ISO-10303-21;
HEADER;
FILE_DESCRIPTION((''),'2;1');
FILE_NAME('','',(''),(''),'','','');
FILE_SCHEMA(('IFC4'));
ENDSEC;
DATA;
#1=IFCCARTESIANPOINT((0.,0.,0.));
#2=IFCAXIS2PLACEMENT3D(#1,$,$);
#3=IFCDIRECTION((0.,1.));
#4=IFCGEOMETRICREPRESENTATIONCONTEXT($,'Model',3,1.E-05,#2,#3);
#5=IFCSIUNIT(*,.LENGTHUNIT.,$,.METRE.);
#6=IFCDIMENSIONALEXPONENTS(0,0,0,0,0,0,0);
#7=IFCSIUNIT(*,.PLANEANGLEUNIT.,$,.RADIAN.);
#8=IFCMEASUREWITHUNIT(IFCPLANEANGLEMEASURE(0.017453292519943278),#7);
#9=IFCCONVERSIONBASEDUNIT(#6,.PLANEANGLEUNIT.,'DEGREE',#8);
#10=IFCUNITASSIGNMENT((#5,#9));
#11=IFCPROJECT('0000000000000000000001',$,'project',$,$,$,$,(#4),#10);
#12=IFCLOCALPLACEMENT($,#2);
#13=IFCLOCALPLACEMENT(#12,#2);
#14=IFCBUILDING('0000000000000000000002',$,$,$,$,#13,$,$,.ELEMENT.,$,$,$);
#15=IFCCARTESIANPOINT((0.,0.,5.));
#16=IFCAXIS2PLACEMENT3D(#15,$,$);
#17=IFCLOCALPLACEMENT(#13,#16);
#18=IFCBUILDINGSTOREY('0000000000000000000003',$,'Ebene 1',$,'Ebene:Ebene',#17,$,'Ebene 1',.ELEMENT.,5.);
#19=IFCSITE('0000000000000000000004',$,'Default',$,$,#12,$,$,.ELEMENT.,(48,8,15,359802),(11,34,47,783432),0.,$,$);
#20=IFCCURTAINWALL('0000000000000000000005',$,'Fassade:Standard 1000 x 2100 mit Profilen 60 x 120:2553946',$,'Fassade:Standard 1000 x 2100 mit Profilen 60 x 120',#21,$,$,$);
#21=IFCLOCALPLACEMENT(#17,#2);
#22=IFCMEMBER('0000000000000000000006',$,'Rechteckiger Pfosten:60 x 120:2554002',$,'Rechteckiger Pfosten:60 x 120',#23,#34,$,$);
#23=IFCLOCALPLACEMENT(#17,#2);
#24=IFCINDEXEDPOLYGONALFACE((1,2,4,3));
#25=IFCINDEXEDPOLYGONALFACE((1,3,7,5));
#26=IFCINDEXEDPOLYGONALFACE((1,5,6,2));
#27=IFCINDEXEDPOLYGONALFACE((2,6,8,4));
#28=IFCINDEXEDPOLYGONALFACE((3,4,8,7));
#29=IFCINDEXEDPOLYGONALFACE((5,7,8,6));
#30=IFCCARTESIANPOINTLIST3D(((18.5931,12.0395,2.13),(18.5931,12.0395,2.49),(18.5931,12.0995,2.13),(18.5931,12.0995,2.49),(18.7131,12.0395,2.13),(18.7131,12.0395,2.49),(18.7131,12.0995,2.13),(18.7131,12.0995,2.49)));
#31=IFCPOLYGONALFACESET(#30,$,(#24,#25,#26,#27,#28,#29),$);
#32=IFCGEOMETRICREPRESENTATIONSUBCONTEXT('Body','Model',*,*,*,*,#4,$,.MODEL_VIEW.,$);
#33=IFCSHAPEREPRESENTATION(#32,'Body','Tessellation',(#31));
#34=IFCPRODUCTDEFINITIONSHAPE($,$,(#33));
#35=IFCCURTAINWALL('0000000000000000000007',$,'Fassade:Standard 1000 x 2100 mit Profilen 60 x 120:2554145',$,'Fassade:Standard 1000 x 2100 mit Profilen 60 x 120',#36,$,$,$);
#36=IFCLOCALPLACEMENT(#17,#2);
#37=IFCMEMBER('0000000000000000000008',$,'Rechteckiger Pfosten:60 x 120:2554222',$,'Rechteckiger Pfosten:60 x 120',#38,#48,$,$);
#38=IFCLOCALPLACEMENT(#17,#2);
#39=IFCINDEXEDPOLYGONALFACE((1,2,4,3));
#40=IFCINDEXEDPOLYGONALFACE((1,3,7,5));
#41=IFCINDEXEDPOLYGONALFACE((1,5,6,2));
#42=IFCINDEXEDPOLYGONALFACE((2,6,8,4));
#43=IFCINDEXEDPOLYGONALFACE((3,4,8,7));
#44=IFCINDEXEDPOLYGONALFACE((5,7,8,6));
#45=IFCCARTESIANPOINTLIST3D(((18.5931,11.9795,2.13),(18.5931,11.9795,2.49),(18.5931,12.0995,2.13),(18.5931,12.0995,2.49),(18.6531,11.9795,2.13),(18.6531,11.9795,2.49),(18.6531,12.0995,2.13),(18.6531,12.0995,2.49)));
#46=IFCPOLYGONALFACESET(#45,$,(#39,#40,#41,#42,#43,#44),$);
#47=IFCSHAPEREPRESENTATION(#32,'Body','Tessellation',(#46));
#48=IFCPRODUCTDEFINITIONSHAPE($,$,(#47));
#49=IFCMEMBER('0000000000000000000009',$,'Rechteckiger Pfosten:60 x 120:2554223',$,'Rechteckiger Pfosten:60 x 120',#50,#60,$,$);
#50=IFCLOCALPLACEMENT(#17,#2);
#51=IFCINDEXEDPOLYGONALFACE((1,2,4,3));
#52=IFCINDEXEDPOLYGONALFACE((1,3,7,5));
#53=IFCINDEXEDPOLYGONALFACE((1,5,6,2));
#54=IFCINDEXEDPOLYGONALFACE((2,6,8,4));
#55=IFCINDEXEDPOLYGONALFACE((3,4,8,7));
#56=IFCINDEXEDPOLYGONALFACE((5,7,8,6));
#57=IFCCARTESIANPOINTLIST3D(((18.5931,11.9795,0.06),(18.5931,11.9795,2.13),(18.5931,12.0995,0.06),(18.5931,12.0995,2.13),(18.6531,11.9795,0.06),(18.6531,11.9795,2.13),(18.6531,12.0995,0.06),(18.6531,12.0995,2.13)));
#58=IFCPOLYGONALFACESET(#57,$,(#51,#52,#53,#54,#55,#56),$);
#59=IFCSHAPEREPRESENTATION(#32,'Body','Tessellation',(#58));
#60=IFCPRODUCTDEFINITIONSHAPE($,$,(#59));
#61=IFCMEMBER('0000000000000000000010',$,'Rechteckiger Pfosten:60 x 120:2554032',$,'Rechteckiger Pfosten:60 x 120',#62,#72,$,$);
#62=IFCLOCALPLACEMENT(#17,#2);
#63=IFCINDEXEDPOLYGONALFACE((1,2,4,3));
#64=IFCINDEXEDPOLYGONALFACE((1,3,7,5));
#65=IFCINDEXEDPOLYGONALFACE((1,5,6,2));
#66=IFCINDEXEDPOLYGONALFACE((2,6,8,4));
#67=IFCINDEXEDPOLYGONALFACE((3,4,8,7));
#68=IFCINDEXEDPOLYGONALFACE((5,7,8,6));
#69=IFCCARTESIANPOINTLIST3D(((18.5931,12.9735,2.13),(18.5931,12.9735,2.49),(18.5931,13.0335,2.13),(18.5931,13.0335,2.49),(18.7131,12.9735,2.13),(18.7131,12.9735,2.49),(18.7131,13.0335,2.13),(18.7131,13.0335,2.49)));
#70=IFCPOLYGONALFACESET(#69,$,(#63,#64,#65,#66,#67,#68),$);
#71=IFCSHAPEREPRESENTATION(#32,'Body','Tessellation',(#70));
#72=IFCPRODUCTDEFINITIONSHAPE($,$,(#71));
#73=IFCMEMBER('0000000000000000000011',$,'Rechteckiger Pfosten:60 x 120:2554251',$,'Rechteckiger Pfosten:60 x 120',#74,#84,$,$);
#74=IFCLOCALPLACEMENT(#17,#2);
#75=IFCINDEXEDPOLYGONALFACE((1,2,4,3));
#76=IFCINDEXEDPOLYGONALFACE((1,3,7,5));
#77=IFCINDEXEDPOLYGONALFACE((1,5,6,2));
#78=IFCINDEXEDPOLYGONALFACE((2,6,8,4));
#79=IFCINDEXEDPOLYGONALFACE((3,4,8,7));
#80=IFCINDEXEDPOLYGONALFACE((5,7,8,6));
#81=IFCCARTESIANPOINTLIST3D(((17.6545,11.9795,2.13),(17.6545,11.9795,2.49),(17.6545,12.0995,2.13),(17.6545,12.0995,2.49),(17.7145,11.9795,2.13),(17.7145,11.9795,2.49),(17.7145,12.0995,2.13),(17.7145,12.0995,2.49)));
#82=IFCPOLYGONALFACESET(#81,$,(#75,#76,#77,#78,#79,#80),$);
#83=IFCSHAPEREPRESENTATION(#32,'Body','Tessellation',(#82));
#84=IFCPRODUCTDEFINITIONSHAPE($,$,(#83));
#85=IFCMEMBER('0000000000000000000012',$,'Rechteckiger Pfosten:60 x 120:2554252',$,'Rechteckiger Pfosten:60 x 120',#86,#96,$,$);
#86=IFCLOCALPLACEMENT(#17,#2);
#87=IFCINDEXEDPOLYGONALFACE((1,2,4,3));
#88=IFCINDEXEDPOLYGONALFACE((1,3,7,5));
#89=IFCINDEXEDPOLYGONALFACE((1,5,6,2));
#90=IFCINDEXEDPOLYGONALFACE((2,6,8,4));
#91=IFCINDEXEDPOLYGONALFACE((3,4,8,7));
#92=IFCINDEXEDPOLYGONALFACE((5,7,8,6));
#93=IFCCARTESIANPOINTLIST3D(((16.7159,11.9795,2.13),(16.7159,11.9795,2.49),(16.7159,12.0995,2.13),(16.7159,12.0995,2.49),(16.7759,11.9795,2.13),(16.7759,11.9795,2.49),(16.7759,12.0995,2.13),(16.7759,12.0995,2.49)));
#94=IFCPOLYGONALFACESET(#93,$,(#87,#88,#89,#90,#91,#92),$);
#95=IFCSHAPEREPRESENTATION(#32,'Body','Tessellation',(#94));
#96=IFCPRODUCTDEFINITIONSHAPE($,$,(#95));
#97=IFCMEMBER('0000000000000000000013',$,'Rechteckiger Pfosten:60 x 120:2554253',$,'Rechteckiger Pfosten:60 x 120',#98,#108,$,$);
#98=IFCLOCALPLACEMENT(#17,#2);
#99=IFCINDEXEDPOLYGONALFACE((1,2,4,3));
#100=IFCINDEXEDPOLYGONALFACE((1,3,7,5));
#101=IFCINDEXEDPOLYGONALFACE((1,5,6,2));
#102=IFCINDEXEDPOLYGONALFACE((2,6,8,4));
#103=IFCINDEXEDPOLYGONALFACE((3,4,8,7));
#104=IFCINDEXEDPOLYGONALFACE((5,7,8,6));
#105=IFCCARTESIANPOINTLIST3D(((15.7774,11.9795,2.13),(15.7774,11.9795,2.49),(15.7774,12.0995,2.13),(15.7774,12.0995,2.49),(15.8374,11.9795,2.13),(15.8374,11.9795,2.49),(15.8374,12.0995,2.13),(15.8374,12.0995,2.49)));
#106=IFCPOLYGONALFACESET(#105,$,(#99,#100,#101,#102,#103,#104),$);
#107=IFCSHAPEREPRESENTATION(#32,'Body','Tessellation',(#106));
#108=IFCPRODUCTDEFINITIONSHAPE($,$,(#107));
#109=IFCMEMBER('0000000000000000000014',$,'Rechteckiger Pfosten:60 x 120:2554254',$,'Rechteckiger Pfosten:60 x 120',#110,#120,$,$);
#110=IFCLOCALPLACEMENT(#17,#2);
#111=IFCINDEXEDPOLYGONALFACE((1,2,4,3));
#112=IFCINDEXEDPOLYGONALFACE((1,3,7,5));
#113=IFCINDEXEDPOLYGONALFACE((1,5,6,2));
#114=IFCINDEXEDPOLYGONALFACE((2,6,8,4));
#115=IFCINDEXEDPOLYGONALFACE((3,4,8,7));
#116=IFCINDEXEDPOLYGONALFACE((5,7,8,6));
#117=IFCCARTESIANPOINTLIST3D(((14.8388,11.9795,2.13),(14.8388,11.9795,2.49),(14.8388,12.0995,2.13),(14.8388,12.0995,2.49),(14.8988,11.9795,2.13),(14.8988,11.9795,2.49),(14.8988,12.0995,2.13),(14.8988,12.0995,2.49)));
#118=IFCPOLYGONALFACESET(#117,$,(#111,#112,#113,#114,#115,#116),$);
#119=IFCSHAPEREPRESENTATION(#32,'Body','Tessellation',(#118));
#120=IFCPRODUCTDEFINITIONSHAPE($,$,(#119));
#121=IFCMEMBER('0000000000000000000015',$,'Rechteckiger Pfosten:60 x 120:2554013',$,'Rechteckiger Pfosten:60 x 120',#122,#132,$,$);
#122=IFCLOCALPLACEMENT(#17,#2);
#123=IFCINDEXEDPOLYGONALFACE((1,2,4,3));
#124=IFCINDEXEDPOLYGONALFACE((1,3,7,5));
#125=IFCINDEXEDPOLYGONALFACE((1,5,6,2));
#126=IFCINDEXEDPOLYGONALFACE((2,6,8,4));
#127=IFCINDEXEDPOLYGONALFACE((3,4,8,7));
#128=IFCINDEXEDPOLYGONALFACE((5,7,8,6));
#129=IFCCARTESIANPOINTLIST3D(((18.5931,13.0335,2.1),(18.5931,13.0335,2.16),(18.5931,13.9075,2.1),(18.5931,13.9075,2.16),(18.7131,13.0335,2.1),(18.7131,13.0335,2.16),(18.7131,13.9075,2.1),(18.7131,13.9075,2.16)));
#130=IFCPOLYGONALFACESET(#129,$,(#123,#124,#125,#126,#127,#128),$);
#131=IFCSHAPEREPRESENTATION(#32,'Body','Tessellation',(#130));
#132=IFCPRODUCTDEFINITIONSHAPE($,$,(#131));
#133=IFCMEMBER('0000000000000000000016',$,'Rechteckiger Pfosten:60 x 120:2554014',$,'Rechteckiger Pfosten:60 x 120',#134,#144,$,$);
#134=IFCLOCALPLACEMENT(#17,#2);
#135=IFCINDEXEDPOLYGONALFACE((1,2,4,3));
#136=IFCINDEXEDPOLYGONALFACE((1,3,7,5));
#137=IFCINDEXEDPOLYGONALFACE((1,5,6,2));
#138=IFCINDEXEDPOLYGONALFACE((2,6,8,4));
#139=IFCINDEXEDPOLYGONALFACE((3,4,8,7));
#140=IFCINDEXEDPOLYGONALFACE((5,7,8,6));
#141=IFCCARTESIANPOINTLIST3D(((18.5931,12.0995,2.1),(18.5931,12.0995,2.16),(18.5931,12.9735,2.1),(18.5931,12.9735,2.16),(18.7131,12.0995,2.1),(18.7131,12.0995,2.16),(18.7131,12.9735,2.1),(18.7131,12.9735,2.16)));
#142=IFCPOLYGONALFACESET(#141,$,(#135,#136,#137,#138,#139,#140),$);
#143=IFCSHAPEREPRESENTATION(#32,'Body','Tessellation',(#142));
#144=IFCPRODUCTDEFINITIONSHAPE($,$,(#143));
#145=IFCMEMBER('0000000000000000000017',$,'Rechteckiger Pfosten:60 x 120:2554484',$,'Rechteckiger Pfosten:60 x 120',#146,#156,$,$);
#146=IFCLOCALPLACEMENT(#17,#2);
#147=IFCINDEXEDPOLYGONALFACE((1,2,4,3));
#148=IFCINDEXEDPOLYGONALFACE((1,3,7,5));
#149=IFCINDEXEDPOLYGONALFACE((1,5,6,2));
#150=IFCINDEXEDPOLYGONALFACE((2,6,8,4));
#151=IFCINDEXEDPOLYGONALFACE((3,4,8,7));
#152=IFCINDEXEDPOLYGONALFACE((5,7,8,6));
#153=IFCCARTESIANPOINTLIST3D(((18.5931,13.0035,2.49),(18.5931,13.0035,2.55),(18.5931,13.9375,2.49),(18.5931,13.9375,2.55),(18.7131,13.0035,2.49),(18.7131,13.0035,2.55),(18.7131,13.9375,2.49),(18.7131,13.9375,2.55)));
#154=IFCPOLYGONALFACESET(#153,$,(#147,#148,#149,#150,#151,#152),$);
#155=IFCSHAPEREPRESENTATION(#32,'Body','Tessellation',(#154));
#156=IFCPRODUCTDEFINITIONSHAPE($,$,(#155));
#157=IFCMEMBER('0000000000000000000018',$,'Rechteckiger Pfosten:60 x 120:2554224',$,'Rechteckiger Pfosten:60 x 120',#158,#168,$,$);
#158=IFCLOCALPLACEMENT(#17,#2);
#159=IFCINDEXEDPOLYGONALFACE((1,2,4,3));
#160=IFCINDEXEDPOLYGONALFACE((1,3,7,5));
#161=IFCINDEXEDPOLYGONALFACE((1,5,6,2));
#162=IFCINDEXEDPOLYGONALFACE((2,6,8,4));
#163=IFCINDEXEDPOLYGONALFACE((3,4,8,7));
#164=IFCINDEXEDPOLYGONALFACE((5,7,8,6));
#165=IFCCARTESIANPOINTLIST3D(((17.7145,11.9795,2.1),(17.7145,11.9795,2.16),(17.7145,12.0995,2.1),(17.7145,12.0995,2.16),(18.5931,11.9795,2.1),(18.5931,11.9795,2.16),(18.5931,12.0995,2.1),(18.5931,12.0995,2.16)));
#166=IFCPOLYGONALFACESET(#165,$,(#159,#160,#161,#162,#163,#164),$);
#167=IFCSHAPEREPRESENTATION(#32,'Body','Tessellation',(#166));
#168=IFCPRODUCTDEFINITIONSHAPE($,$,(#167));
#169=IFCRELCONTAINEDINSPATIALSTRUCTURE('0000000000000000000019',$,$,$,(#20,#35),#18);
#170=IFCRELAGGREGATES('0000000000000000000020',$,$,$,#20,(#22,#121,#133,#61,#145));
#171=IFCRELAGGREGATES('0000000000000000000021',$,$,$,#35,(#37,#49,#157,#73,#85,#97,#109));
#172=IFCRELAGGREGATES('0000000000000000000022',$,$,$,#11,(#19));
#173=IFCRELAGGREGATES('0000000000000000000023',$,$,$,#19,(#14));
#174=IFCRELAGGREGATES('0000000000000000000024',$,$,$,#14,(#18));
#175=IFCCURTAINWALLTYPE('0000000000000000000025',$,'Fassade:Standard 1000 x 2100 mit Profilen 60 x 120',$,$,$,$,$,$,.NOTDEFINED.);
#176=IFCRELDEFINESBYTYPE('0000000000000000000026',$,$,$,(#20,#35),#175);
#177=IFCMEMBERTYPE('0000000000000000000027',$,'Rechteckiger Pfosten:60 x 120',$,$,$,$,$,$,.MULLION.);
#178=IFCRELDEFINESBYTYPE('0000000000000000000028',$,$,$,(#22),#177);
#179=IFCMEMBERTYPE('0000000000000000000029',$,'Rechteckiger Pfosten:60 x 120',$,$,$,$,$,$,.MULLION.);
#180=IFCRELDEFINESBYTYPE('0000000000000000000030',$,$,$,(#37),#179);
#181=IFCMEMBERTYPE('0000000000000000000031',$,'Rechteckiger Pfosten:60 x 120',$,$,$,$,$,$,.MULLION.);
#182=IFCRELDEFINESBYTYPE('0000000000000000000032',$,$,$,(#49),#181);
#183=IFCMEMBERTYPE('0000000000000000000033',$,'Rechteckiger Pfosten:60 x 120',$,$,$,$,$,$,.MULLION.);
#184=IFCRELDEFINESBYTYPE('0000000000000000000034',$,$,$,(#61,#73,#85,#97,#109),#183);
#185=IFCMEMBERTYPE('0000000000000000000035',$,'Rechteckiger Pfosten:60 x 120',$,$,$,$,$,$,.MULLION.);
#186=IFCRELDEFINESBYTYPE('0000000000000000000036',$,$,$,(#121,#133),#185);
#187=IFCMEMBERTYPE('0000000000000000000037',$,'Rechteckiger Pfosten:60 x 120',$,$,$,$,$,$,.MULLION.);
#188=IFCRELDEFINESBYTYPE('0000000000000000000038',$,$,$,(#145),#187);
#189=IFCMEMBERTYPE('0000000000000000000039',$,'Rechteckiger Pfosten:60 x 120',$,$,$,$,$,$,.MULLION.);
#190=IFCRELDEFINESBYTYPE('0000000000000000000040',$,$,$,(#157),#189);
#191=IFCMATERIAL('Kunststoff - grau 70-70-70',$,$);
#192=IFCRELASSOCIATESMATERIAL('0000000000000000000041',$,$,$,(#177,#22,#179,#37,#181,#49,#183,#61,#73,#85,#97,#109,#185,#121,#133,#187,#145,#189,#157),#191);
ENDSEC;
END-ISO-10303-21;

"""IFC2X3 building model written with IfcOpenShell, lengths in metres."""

from ifc_helpers import new_model, entity, si_unit, converted_unit, direction, frame, frame_2d, origin, origin_2d_with_axis, place, context, subcontext, project, spatial, rectangle, extrude, source, transform, mapped, material, type_object, type_shapes, element, aggregate, save


model = new_model("IFC2X3")

# Units and contexts
model_context = context("Model", 3, precision=1e-05, world=origin(), true_north=direction((0.0, 1.0)))
body_context = subcontext(model_context, "Body", "Model", "MODEL_VIEW")
ifc_project = project(units=[si_unit("LENGTHUNIT", "METRE"), converted_unit("PLANEANGLEUNIT", "DEGREE", entity("IfcPlaneAngleMeasure", 0.017453292519943278), si_unit("PLANEANGLEUNIT", "RADIAN"), dimensions=[0, 0, 0, 0, 0, 0, 0])], contexts=[model_context])

# Site, building, storey
site_placement = place(None, origin())
site = spatial("IfcSite", under=ifc_project, at=site_placement, Name="Default", CompositionType="ELEMENT", RefLatitude=(48, 8, 15, 359802), RefLongitude=(11, 34, 47, 783432), RefElevation=0.0)
building_placement = place(site_placement, origin())
building = spatial("IfcBuilding", under=site, at=building_placement, CompositionType="ELEMENT")
storey_placement = place(building_placement, frame((0.0, 0.0, 5.0)))
storey = spatial("IfcBuildingStorey", under=building, at=storey_placement, Name="Ebene 1", ObjectType="Ebene:Ebene", LongName="Ebene 1", CompositionType="ELEMENT", Elevation=5.0)

# Curtain wall, member
curtain_wall_type = type_object("IfcCurtainWallType", Name="Fassade:Standard 1000 x 2100 mit Profilen 60 x 120", PredefinedType="NOTDEFINED")
curtain_wall_1_placement = place(storey_placement, frame((0.0, 0.0, -5.0)))
curtain_wall_1 = element("IfcCurtainWall", 1, at=curtain_wall_1_placement, inside=storey, type_object=curtain_wall_type, Name="Fassade:Standard 1000 x 2100 mit Profilen 60 x 120:2553946", ObjectType="Fassade:Standard 1000 x 2100 mit Profilen 60 x 120")
ifc_material_1 = material(Name="Kunststoff - grau 70-70-70")
member_type_1 = type_object("IfcMemberType", Name="Rechteckiger Pfosten:60 x 120", PredefinedType="MULLION", material=ifc_material_1)
shared_shape_1 = source(origin(), body_context, "Body", "SweptSolid", [
    extrude(rectangle(XDim=0.06, YDim=0.12, at=origin_2d_with_axis()), frame((-0.03, 0.0, -0.36), z_axis=(0.0, 0.0, 1.0), x_axis=(-1.0, 0.0, 0.0)), (0.0, 0.0, 1.0), 0.36),
])
type_shapes(member_type_1, [shared_shape_1])
member_1_placement = place(curtain_wall_1_placement, frame((18.6531, 12.0395, 7.13), z_axis=(0.0, 0.0, -1.0), x_axis=(0.0, -1.0, 0.0)))
member_1 = element("IfcMember", 2, at=member_1_placement, type_object=member_type_1, material=ifc_material_1, Name="Rechteckiger Pfosten:60 x 120:2554002", ObjectType="Rechteckiger Pfosten:60 x 120", context=body_context, shape_type="MappedRepresentation", body=[
    mapped(shared_shape_1, transform((0.0, 0.0, 0.0), scale=1.0)),
])

# Curtain wall, members
curtain_wall_2_placement = place(storey_placement, frame((0.0, 0.0, -5.0)))
curtain_wall_2 = element("IfcCurtainWall", 3, at=curtain_wall_2_placement, inside=storey, type_object=curtain_wall_type, Name="Fassade:Standard 1000 x 2100 mit Profilen 60 x 120:2554145", ObjectType="Fassade:Standard 1000 x 2100 mit Profilen 60 x 120")
member_type_2 = type_object("IfcMemberType", Name="Rechteckiger Pfosten:60 x 120", PredefinedType="MULLION", material=ifc_material_1)
shared_shape_2 = source(origin(), body_context, "Body", "SweptSolid", [
    extrude(rectangle(XDim=0.06, YDim=0.12, at=origin_2d_with_axis()), frame((-0.03, 0.0, -0.36), z_axis=(0.0, 0.0, 1.0), x_axis=(-1.0, 0.0, 0.0)), (0.0, 0.0, 1.0), 0.36),
])
type_shapes(member_type_2, [shared_shape_2])
member_2_placement = place(curtain_wall_2_placement, frame((18.6531, 12.0395, 7.49)))
member_2 = element("IfcMember", 4, at=member_2_placement, type_object=member_type_2, material=ifc_material_1, Name="Rechteckiger Pfosten:60 x 120:2554222", ObjectType="Rechteckiger Pfosten:60 x 120", context=body_context, shape_type="MappedRepresentation", body=[
    mapped(shared_shape_2, transform((0.0, 0.0, 0.0), scale=1.0)),
])
member_type_3 = type_object("IfcMemberType", Name="Rechteckiger Pfosten:60 x 120", PredefinedType="MULLION", material=ifc_material_1)
shared_shape_3 = source(origin(), body_context, "Body", "SweptSolid", [
    extrude(rectangle(XDim=0.06, YDim=0.12, at=origin_2d_with_axis()), frame((-0.03, 0.0, -2.07), z_axis=(0.0, 0.0, 1.0), x_axis=(-1.0, 0.0, 0.0)), (0.0, 0.0, 1.0), 2.07),
])
type_shapes(member_type_3, [shared_shape_3])
member_3_placement = place(curtain_wall_2_placement, frame((18.6531, 12.0395, 7.13)))
member_3 = element("IfcMember", 5, at=member_3_placement, type_object=member_type_3, material=ifc_material_1, Name="Rechteckiger Pfosten:60 x 120:2554223", ObjectType="Rechteckiger Pfosten:60 x 120", context=body_context, shape_type="MappedRepresentation", body=[
    mapped(shared_shape_3, transform((0.0, 0.0, 0.0), scale=1.0)),
])

# Members
member_type_4 = type_object("IfcMemberType", Name="Rechteckiger Pfosten:60 x 120", PredefinedType="MULLION", material=ifc_material_1)
shared_shape_4 = source(origin(), body_context, "Body", "SweptSolid", [
    extrude(rectangle(XDim=0.06, YDim=0.12, at=frame_2d((0.0, 0.0), x_axis=(1.0, 0.0))), frame((0.0, 0.0, -0.36), z_axis=(0.0, 0.0, 1.0), x_axis=(-1.0, 0.0, 0.0)), (0.0, 0.0, 1.0), 0.36),
])
type_shapes(member_type_4, [shared_shape_4])
member_4_placement = place(curtain_wall_1_placement, frame((18.6531, 13.0035, 7.13), z_axis=(0.0, 0.0, -1.0), x_axis=(0.0, -1.0, 0.0)))
member_4 = element("IfcMember", 6, at=member_4_placement, type_object=member_type_4, material=ifc_material_1, Name="Rechteckiger Pfosten:60 x 120:2554032", ObjectType="Rechteckiger Pfosten:60 x 120", context=body_context, shape_type="MappedRepresentation", body=[
    mapped(shared_shape_4, transform((0.0, 0.0, 0.0), scale=1.0)),
])
member_5_placement = place(curtain_wall_2_placement, frame((17.6845, 12.0395, 7.13), z_axis=(0.0, 0.0, -1.0), x_axis=(-1.0, 0.0, 0.0)))
member_5 = element("IfcMember", 7, at=member_5_placement, type_object=member_type_4, material=ifc_material_1, Name="Rechteckiger Pfosten:60 x 120:2554251", ObjectType="Rechteckiger Pfosten:60 x 120", context=body_context, shape_type="MappedRepresentation", body=[
    mapped(shared_shape_4, transform((0.0, 0.0, 0.0), scale=1.0)),
])
member_6_placement = place(curtain_wall_2_placement, frame((16.7459, 12.0395, 7.13), z_axis=(0.0, 0.0, -1.0), x_axis=(-1.0, 0.0, 0.0)))
member_6 = element("IfcMember", 8, at=member_6_placement, type_object=member_type_4, material=ifc_material_1, Name="Rechteckiger Pfosten:60 x 120:2554252", ObjectType="Rechteckiger Pfosten:60 x 120", context=body_context, shape_type="MappedRepresentation", body=[
    mapped(shared_shape_4, transform((0.0, 0.0, 0.0), scale=1.0)),
])
member_7_placement = place(curtain_wall_2_placement, frame((15.8074, 12.0395, 7.13), z_axis=(0.0, 0.0, -1.0), x_axis=(-1.0, 0.0, 0.0)))
member_7 = element("IfcMember", 9, at=member_7_placement, type_object=member_type_4, material=ifc_material_1, Name="Rechteckiger Pfosten:60 x 120:2554253", ObjectType="Rechteckiger Pfosten:60 x 120", context=body_context, shape_type="MappedRepresentation", body=[
    mapped(shared_shape_4, transform((0.0, 0.0, 0.0), scale=1.0)),
])
member_8_placement = place(curtain_wall_2_placement, frame((14.8688, 12.0395, 7.13), z_axis=(0.0, 0.0, -1.0), x_axis=(-1.0, 0.0, 0.0)))
member_8 = element("IfcMember", 10, at=member_8_placement, type_object=member_type_4, material=ifc_material_1, Name="Rechteckiger Pfosten:60 x 120:2554254", ObjectType="Rechteckiger Pfosten:60 x 120", context=body_context, shape_type="MappedRepresentation", body=[
    mapped(shared_shape_4, transform((0.0, 0.0, 0.0), scale=1.0)),
])
member_type_5 = type_object("IfcMemberType", Name="Rechteckiger Pfosten:60 x 120", PredefinedType="MULLION", material=ifc_material_1)
shared_shape_5 = source(origin(), body_context, "Body", "SweptSolid", [
    extrude(rectangle(XDim=0.06, YDim=0.12, at=frame_2d((0.0, 0.0), x_axis=(1.0, 0.0))), frame((0.0, 0.0, -0.874), z_axis=(0.0, 0.0, 1.0), x_axis=(-1.0, 0.0, 0.0)), (0.0, 0.0, 1.0), 0.874),
])
type_shapes(member_type_5, [shared_shape_5])
member_9_placement = place(curtain_wall_1_placement, frame((18.6531, 13.0335, 7.13), z_axis=(0.0, -1.0, 0.0), x_axis=(0.0, 0.0, 1.0)))
member_9 = element("IfcMember", 11, at=member_9_placement, type_object=member_type_5, material=ifc_material_1, Name="Rechteckiger Pfosten:60 x 120:2554013", ObjectType="Rechteckiger Pfosten:60 x 120", context=body_context, shape_type="MappedRepresentation", body=[
    mapped(shared_shape_5, transform((0.0, 0.0, 0.0), scale=1.0)),
])
member_10_placement = place(curtain_wall_1_placement, frame((18.6531, 12.0995, 7.13), z_axis=(0.0, -1.0, 0.0), x_axis=(0.0, 0.0, 1.0)))
member_10 = element("IfcMember", 12, at=member_10_placement, type_object=member_type_5, material=ifc_material_1, Name="Rechteckiger Pfosten:60 x 120:2554014", ObjectType="Rechteckiger Pfosten:60 x 120", context=body_context, shape_type="MappedRepresentation", body=[
    mapped(shared_shape_5, transform((0.0, 0.0, 0.0), scale=1.0)),
])
member_type_6 = type_object("IfcMemberType", Name="Rechteckiger Pfosten:60 x 120", PredefinedType="MULLION", material=ifc_material_1)
shared_shape_6 = source(origin(), body_context, "Body", "SweptSolid", [
    extrude(rectangle(XDim=0.06, YDim=0.12, at=origin_2d_with_axis()), frame((-0.03, 0.0, -0.934), z_axis=(0.0, 0.0, 1.0), x_axis=(-1.0, 0.0, 0.0)), (0.0, 0.0, 1.0), 0.934),
])
type_shapes(member_type_6, [shared_shape_6])
member_11_placement = place(curtain_wall_1_placement, frame((18.6531, 13.0035, 7.55), z_axis=(0.0, -1.0, 0.0), x_axis=(0.0, 0.0, 1.0)))
member_11 = element("IfcMember", 13, at=member_11_placement, type_object=member_type_6, material=ifc_material_1, Name="Rechteckiger Pfosten:60 x 120:2554484", ObjectType="Rechteckiger Pfosten:60 x 120", context=body_context, shape_type="MappedRepresentation", body=[
    mapped(shared_shape_6, transform((0.0, 0.0, 0.0), scale=1.0)),
])
member_type_7 = type_object("IfcMemberType", Name="Rechteckiger Pfosten:60 x 120", PredefinedType="MULLION", material=ifc_material_1)
shared_shape_7 = source(origin(), body_context, "Body", "SweptSolid", [
    extrude(rectangle(XDim=0.06, YDim=0.12, at=frame_2d((0.0, 0.0), x_axis=(1.0, 0.0))), frame((0.0, 0.0, -0.8786), z_axis=(0.0, 0.0, 1.0), x_axis=(-1.0, 0.0, 0.0)), (0.0, 0.0, 1.0), 0.8786),
])
type_shapes(member_type_7, [shared_shape_7])
member_12_placement = place(curtain_wall_2_placement, frame((17.7145, 12.0395, 7.13), z_axis=(-1.0, 0.0, 0.0), x_axis=(0.0, 0.0, 1.0)))
member_12 = element("IfcMember", 14, at=member_12_placement, type_object=member_type_7, material=ifc_material_1, Name="Rechteckiger Pfosten:60 x 120:2554224", ObjectType="Rechteckiger Pfosten:60 x 120", context=body_context, shape_type="MappedRepresentation", body=[
    mapped(shared_shape_7, transform((0.0, 0.0, 0.0), scale=1.0)),
])

aggregate(curtain_wall_1, [member_1, member_9, member_10, member_4, member_11])
aggregate(curtain_wall_2, [member_2, member_3, member_12, member_5, member_6, member_7, member_8])

save(model, "model.ifc")
